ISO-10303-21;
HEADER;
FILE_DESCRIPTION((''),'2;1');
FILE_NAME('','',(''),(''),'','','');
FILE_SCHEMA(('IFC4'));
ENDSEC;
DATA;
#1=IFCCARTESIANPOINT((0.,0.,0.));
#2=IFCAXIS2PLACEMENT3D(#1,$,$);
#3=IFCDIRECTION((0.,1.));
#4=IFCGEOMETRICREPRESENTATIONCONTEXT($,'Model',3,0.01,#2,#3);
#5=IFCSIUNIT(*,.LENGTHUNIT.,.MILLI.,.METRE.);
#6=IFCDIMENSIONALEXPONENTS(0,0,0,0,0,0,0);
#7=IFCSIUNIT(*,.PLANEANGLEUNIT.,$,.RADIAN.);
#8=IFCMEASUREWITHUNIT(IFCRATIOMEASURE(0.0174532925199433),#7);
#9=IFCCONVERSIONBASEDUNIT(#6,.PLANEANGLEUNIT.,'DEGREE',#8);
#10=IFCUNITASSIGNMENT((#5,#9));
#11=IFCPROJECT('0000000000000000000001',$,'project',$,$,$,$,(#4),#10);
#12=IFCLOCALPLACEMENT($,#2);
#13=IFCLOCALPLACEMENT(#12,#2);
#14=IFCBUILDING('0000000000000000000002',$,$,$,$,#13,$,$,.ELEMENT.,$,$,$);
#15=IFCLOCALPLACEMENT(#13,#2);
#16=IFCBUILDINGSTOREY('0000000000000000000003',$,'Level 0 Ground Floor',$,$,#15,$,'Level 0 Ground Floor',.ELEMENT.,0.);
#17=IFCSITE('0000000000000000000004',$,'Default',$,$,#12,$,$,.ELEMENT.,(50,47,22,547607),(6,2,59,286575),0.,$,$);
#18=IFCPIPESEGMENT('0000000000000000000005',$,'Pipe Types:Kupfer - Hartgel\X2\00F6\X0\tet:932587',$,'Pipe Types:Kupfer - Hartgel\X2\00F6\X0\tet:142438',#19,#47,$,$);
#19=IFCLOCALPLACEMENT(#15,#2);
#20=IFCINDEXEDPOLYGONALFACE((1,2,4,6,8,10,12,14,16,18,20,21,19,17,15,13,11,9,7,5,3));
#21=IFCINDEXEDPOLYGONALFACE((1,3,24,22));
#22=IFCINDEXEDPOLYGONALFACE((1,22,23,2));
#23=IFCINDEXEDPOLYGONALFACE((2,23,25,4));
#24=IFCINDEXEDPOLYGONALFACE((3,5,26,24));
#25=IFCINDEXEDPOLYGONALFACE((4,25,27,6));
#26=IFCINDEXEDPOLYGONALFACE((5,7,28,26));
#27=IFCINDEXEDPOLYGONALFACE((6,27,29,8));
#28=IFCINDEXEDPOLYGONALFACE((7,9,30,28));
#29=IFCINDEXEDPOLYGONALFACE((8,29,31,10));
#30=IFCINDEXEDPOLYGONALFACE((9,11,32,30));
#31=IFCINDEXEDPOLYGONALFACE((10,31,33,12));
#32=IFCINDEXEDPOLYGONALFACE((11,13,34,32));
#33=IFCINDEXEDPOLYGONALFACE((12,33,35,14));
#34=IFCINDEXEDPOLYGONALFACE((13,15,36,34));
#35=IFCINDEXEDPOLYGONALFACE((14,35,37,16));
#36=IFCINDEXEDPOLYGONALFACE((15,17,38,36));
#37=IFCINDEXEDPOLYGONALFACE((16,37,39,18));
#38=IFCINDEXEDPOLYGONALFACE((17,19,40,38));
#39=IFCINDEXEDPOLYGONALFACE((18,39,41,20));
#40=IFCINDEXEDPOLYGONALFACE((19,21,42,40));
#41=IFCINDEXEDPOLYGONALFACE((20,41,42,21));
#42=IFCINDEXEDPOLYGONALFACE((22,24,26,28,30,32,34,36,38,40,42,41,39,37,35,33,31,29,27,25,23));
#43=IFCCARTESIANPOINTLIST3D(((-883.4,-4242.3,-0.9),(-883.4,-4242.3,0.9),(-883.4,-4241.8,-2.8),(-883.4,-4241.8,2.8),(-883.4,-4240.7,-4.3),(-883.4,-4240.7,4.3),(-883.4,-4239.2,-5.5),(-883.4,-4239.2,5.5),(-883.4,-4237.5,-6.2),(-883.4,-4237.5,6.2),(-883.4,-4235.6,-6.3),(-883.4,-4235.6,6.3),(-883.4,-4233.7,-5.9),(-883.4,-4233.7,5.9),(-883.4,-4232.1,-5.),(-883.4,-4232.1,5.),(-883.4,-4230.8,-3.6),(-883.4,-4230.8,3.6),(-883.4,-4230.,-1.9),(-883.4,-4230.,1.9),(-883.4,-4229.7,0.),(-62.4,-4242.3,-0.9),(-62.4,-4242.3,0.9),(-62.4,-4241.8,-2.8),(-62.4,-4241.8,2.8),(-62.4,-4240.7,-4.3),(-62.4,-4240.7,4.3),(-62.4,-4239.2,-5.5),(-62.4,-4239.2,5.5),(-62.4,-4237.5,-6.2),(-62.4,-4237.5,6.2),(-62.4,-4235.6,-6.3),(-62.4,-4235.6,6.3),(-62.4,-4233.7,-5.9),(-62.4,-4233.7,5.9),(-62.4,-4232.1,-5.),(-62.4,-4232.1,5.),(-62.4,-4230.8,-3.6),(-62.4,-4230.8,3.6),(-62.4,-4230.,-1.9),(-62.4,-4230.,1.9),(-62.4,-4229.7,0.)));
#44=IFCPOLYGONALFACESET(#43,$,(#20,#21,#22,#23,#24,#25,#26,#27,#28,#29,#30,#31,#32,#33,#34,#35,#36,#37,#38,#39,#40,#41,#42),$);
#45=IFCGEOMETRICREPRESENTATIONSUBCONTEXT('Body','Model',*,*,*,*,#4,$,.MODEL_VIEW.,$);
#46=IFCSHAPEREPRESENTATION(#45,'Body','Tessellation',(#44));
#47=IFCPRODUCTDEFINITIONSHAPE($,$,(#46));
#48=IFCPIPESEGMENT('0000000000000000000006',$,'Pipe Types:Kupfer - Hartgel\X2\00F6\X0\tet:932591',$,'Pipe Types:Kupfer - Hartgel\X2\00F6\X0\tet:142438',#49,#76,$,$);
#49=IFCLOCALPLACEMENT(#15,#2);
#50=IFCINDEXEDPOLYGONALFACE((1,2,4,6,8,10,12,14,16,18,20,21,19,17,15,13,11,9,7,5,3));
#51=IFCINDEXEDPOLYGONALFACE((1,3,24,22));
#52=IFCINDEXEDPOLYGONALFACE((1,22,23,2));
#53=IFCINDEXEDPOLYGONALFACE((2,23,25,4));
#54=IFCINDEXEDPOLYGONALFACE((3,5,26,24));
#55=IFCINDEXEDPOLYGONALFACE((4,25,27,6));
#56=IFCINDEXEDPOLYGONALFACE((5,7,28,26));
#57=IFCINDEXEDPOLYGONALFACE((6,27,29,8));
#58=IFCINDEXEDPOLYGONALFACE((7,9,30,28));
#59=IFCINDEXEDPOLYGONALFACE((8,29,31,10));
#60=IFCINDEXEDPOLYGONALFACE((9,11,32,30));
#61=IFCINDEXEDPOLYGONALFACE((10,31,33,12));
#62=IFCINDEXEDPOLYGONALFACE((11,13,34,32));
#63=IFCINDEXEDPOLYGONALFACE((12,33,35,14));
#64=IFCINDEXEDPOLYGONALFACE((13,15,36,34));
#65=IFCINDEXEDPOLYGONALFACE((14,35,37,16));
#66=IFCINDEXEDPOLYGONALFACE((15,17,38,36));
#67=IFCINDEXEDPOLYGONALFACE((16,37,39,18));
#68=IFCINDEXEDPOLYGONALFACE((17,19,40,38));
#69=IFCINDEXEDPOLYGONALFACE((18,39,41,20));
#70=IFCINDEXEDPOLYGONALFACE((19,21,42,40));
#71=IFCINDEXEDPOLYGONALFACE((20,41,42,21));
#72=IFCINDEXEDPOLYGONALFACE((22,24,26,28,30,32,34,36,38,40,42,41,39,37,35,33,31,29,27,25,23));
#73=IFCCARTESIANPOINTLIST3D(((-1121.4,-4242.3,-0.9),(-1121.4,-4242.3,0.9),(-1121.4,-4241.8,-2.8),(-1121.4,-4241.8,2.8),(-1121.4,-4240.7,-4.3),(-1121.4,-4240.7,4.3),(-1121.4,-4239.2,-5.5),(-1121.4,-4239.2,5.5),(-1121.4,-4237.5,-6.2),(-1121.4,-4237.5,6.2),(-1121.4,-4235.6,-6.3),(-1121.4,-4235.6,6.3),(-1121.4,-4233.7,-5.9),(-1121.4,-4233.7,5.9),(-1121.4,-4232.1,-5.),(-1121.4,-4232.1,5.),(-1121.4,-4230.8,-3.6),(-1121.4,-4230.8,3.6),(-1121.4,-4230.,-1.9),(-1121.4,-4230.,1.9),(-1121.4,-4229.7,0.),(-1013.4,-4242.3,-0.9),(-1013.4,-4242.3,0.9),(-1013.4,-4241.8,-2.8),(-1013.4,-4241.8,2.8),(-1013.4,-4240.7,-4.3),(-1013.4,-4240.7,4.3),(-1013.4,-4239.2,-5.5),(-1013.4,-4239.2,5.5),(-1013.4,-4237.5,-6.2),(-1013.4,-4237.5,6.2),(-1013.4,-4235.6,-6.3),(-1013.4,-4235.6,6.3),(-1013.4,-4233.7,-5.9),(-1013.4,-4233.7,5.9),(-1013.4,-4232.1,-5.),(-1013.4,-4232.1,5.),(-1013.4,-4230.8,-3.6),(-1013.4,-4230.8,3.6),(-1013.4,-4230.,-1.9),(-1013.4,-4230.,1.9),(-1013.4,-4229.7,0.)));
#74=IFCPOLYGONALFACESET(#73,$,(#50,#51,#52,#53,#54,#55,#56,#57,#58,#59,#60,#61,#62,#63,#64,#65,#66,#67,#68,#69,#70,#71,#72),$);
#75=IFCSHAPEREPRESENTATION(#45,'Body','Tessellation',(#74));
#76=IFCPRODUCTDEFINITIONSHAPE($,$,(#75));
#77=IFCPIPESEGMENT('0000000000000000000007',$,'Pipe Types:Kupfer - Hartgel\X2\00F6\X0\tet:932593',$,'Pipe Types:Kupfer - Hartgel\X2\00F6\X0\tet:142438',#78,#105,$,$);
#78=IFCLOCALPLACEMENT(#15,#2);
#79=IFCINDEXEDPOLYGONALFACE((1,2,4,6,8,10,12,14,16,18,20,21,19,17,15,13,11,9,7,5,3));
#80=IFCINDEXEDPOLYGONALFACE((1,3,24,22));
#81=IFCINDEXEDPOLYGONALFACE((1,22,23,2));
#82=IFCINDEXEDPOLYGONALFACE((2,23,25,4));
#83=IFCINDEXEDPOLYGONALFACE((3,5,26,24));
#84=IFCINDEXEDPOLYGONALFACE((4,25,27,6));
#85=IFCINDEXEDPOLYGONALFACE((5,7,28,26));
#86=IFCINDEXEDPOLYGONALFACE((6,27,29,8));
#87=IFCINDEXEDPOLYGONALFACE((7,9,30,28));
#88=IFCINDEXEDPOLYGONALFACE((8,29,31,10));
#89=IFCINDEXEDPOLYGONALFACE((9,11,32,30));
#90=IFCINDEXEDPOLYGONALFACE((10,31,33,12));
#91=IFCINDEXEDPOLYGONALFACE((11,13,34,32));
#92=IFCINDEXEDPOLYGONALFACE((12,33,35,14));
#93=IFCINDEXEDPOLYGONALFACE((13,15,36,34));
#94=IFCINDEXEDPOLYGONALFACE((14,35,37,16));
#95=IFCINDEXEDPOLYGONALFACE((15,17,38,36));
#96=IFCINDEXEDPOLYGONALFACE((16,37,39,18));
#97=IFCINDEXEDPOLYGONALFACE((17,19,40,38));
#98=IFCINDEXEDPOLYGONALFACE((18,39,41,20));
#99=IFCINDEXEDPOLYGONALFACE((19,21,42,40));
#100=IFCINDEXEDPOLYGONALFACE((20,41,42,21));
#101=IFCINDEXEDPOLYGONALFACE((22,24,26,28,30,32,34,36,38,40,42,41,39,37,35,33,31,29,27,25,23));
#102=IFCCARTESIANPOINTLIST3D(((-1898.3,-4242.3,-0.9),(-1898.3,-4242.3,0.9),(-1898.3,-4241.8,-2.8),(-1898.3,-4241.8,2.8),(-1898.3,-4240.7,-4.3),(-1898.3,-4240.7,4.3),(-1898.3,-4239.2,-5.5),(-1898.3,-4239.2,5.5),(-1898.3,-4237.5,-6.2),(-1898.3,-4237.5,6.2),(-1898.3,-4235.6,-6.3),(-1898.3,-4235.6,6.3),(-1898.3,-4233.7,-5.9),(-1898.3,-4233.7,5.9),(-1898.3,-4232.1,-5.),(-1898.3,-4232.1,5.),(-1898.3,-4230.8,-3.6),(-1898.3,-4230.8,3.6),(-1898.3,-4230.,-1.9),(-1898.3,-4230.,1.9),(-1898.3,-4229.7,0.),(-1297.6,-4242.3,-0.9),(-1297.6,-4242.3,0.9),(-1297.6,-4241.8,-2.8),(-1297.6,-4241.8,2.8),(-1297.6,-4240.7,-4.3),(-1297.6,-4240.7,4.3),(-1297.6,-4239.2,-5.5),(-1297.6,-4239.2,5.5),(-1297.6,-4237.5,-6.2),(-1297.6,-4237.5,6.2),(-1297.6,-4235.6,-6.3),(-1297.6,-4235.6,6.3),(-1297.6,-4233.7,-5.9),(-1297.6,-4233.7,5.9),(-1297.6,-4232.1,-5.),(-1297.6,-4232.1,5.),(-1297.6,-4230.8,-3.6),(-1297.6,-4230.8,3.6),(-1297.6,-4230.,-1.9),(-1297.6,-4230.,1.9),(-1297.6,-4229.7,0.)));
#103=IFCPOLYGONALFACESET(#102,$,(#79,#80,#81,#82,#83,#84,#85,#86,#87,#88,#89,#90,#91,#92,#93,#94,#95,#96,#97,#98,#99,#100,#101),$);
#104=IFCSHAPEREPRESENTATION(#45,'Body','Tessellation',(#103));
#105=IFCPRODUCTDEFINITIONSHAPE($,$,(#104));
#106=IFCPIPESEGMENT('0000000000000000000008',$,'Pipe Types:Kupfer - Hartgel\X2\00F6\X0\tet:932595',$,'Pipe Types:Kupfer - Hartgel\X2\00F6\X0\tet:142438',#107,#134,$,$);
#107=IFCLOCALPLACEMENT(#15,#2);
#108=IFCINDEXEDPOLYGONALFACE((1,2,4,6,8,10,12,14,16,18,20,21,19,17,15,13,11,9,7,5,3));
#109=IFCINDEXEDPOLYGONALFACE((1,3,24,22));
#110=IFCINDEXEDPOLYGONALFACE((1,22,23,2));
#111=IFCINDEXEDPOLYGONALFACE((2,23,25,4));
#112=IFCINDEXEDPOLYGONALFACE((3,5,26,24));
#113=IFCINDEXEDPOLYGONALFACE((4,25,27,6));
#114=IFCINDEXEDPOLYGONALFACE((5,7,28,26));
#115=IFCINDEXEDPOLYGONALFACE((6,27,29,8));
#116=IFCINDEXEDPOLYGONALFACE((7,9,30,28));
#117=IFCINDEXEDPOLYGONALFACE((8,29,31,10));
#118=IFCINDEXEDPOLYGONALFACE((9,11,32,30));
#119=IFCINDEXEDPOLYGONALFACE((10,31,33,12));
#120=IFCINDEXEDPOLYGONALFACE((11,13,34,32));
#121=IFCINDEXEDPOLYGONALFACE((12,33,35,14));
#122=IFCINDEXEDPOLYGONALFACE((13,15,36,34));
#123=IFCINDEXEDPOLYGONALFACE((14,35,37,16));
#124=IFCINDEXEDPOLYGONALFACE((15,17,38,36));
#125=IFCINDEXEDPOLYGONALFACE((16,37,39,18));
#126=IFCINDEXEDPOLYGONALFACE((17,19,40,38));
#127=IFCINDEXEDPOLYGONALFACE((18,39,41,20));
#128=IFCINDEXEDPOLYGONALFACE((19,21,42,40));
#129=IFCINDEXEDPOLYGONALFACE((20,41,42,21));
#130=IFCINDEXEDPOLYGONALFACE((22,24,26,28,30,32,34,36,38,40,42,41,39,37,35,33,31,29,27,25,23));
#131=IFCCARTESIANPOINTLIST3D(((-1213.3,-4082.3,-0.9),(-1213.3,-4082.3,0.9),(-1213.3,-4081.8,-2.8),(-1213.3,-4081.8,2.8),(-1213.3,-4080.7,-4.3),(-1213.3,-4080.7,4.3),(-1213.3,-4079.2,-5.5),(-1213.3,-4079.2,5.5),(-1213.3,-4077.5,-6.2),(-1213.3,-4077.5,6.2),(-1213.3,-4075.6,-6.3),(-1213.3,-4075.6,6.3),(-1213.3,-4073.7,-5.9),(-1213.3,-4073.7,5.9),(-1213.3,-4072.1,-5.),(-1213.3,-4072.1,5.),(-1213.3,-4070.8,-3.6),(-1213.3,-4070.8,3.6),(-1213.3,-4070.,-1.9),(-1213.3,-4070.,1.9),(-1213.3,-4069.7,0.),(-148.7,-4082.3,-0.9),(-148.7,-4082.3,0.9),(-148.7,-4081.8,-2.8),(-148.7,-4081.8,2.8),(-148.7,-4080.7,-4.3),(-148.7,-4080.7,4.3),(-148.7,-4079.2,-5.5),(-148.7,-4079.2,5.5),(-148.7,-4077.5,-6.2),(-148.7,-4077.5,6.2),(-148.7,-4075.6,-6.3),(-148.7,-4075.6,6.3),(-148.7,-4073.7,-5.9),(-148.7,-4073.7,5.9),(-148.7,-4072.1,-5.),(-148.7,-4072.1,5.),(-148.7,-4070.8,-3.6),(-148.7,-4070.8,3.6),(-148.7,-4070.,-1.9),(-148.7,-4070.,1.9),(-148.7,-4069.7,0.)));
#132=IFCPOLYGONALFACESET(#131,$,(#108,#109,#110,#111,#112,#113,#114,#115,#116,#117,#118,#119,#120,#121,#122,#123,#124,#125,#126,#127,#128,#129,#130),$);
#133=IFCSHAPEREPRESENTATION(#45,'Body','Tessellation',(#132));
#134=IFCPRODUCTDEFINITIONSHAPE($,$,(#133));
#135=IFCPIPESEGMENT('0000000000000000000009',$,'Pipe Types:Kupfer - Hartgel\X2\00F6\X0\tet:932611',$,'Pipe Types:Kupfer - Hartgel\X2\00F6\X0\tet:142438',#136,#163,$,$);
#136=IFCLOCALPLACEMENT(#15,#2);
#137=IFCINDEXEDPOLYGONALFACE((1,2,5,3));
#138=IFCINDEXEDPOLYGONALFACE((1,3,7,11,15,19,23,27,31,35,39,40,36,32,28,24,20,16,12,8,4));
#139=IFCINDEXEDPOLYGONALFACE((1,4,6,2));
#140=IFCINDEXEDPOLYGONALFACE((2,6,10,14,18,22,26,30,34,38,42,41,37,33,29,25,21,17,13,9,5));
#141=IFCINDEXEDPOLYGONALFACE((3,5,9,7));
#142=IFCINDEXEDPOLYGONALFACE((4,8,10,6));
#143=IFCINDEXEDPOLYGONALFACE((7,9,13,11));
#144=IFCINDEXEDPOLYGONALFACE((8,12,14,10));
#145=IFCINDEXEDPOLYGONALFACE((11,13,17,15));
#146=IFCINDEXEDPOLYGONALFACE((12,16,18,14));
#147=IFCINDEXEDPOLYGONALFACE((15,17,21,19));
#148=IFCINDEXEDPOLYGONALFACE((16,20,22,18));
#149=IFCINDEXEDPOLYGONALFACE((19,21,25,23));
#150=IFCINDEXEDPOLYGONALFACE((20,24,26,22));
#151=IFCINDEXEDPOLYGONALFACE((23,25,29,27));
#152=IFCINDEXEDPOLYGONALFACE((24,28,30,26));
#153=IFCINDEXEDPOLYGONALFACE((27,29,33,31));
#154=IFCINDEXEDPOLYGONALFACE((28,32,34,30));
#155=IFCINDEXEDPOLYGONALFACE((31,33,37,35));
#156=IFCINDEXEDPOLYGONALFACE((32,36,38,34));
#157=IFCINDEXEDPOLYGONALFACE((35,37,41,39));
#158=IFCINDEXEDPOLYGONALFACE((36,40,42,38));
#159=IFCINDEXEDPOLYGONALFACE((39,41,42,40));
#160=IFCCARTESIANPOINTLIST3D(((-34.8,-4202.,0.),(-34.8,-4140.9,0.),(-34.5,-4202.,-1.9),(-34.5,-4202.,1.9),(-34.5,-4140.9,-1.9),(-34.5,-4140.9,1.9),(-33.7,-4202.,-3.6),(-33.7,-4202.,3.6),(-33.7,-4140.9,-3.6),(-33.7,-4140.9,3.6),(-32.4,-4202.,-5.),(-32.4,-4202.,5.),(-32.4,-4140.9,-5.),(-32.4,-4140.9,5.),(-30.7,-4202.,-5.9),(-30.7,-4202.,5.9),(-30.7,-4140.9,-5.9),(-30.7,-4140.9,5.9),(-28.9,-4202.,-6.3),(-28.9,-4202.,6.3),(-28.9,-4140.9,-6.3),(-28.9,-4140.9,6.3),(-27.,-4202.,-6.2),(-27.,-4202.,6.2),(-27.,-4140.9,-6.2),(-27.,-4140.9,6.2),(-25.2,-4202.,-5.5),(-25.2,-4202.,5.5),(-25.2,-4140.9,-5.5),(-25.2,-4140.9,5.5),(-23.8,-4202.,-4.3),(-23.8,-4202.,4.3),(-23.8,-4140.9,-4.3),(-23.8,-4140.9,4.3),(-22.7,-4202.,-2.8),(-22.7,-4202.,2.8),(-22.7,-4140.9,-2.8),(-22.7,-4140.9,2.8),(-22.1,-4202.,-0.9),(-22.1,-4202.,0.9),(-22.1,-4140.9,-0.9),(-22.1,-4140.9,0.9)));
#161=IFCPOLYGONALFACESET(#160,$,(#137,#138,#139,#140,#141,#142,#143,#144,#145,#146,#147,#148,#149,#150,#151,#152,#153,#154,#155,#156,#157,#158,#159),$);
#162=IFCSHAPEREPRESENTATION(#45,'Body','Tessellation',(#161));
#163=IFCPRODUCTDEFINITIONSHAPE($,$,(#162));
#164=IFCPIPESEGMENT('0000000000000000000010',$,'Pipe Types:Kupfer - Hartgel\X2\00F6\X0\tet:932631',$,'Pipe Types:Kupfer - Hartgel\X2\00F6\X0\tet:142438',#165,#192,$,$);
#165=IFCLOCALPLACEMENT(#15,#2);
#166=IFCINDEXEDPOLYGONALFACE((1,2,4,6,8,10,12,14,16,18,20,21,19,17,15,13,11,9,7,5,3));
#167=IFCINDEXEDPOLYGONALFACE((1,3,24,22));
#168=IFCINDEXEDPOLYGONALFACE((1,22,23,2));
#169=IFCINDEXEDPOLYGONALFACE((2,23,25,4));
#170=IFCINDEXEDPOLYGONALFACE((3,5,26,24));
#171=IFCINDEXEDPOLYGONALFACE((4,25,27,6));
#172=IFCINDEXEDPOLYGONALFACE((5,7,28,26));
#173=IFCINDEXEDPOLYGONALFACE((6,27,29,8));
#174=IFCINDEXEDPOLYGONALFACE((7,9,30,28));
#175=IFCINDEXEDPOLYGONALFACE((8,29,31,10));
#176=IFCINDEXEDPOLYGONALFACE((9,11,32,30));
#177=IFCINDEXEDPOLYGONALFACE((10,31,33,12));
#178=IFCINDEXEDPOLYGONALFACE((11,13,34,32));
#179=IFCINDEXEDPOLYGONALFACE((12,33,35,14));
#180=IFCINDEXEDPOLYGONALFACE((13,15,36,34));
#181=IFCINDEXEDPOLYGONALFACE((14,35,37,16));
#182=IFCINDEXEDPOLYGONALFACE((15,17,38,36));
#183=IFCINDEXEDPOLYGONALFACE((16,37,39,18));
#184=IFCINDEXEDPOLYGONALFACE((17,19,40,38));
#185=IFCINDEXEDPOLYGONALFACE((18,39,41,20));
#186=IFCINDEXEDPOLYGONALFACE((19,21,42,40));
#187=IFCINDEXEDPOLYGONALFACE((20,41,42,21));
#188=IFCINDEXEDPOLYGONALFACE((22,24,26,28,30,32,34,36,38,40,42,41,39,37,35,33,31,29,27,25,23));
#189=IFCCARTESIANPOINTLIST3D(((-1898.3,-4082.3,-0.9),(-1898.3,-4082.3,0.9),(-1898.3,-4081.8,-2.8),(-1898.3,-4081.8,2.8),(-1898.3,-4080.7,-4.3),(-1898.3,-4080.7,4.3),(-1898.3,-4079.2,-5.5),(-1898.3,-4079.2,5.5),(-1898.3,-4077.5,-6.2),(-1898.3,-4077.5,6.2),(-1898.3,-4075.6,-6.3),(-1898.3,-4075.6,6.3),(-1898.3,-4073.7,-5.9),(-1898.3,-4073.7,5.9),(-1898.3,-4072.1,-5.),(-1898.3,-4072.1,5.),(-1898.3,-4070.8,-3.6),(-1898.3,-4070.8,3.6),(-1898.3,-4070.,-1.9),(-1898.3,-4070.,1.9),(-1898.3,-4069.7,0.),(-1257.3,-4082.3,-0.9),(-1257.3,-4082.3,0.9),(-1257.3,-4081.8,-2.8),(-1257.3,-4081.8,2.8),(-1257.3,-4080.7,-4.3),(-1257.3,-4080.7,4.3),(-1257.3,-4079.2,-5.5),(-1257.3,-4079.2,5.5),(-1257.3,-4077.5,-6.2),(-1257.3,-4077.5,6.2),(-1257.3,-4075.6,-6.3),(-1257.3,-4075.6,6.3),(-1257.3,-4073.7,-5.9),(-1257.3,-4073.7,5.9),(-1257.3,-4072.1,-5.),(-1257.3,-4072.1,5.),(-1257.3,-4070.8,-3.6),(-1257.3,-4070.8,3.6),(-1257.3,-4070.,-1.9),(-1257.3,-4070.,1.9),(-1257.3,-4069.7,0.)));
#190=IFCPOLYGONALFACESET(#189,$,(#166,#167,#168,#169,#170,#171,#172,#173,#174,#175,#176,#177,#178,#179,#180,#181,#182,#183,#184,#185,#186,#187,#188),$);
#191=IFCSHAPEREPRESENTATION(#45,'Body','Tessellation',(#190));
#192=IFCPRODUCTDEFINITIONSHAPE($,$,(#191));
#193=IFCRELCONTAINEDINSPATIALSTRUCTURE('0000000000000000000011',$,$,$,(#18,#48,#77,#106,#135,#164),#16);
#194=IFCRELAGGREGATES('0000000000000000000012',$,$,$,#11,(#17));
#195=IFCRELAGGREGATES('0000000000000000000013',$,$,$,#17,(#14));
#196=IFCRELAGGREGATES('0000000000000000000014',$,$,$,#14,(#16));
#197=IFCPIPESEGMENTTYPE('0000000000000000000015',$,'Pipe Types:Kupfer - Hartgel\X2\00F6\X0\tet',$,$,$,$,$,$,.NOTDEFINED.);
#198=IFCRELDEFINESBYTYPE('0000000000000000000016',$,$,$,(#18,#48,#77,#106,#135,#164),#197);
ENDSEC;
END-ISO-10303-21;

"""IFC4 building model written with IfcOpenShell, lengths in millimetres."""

from ifc_helpers import new_model, entity, si_unit, converted_unit, direction, frame, frame_2d, origin, place, context, subcontext, project, spatial, circle, extrude, type_object, element, save


model = new_model("IFC4")

# Units and contexts
model_context = context("Model", 3, precision=0.01, world=origin(), true_north=direction((0.0, 1.0)))
body_context = subcontext(model_context, "Body", "Model", "MODEL_VIEW")
ifc_project = project(units=[si_unit("LENGTHUNIT", "METRE", prefix="MILLI"), converted_unit("PLANEANGLEUNIT", "DEGREE", entity("IfcRatioMeasure", 0.0174532925199433), si_unit("PLANEANGLEUNIT", "RADIAN"), dimensions=[0, 0, 0, 0, 0, 0, 0])], contexts=[model_context])

# Site, building, storey
site_placement = place(None, origin())
site = spatial("IfcSite", under=ifc_project, at=site_placement, Name="Default", CompositionType="ELEMENT", RefLatitude=(50, 47, 22, 547607), RefLongitude=(6, 2, 59, 286575), RefElevation=0.0)
building_placement = place(site_placement, origin())
building = spatial("IfcBuilding", under=site, at=building_placement, CompositionType="ELEMENT")
storey_placement = place(building_placement, origin())
storey = spatial("IfcBuildingStorey", under=building, at=storey_placement, Name="Level 0 Ground Floor", LongName="Level 0 Ground Floor", CompositionType="ELEMENT", Elevation=0.0)

# Pipe segments
pipe_segment_type_1 = type_object("IfcPipeSegmentType", Name="Pipe Types:Kupfer - Hartgelötet", PredefinedType="NOTDEFINED")
pipe_segment_1_placement = place(storey_placement, frame((-883.4, -4244.0, -7.9)))
element("IfcPipeSegment", 1, at=pipe_segment_1_placement, inside=storey, type_object=pipe_segment_type_1, Name="Pipe Types:Kupfer - Hartgelötet:932587", ObjectType="Pipe Types:Kupfer - Hartgelötet:142438", context=body_context, shape_type="SweptSolid", body=[
    extrude(circle(Radius=6.3, at=frame_2d((0.0, 0.0), x_axis=(1.0, 0.0))), frame((0.0, 7.9, 7.9), z_axis=(1.0, 0.0, 0.0), x_axis=(0.0, 1.0, 0.0)), (0.0, 0.0, 1.0), 821.0),
])
pipe_segment_2_placement = place(storey_placement, frame((-1121.4, -4244.0, -7.9)))
element("IfcPipeSegment", 2, at=pipe_segment_2_placement, inside=storey, type_object=pipe_segment_type_1, Name="Pipe Types:Kupfer - Hartgelötet:932591", ObjectType="Pipe Types:Kupfer - Hartgelötet:142438", context=body_context, shape_type="SweptSolid", body=[
    extrude(circle(Radius=6.3, at=frame_2d((0.0, 0.0), x_axis=(1.0, 0.0))), frame((0.0, 7.9, 7.9), z_axis=(1.0, 0.0, 0.0), x_axis=(0.0, 1.0, 0.0)), (0.0, 0.0, 1.0), 108.0),
])
pipe_segment_3_placement = place(storey_placement, frame((-1898.3, -4244.0, -7.9)))
element("IfcPipeSegment", 3, at=pipe_segment_3_placement, inside=storey, type_object=pipe_segment_type_1, Name="Pipe Types:Kupfer - Hartgelötet:932593", ObjectType="Pipe Types:Kupfer - Hartgelötet:142438", context=body_context, shape_type="SweptSolid", body=[
    extrude(circle(Radius=6.3, at=frame_2d((0.0, 0.0), x_axis=(1.0, 0.0))), frame((0.0, 7.9, 7.9), z_axis=(1.0, 0.0, 0.0), x_axis=(0.0, 1.0, 0.0)), (0.0, 0.0, 1.0), 600.7),
])
pipe_segment_4_placement = place(storey_placement, frame((-1213.3, -4084.0, -7.9)))
element("IfcPipeSegment", 4, at=pipe_segment_4_placement, inside=storey, type_object=pipe_segment_type_1, Name="Pipe Types:Kupfer - Hartgelötet:932595", ObjectType="Pipe Types:Kupfer - Hartgelötet:142438", context=body_context, shape_type="SweptSolid", body=[
    extrude(circle(Radius=6.3, at=frame_2d((0.0, 0.0), x_axis=(1.0, 0.0))), frame((0.0, 7.9, 7.9), z_axis=(1.0, 0.0, 0.0), x_axis=(0.0, 1.0, 0.0)), (0.0, 0.0, 1.0), 1064.6),
])
pipe_segment_5_placement = place(storey_placement, frame((-36.4, -4202.0, -7.9)))
element("IfcPipeSegment", 5, at=pipe_segment_5_placement, inside=storey, type_object=pipe_segment_type_1, Name="Pipe Types:Kupfer - Hartgelötet:932611", ObjectType="Pipe Types:Kupfer - Hartgelötet:142438", context=body_context, shape_type="SweptSolid", body=[
    extrude(circle(Radius=6.3, at=frame_2d((0.0, 0.0), x_axis=(1.0, 0.0))), frame((7.9, 0.0, 7.9), z_axis=(0.0, 1.0, 0.0), x_axis=(-1.0, 0.0, 0.0)), (0.0, 0.0, 1.0), 61.1),
])
pipe_segment_6_placement = place(storey_placement, frame((-1898.3, -4084.0, -7.9)))
element("IfcPipeSegment", 6, at=pipe_segment_6_placement, inside=storey, type_object=pipe_segment_type_1, Name="Pipe Types:Kupfer - Hartgelötet:932631", ObjectType="Pipe Types:Kupfer - Hartgelötet:142438", context=body_context, shape_type="SweptSolid", body=[
    extrude(circle(Radius=6.3, at=frame_2d((0.0, 0.0), x_axis=(1.0, 0.0))), frame((0.0, 7.9, 7.9), z_axis=(1.0, 0.0, 0.0), x_axis=(0.0, 1.0, 0.0)), (0.0, 0.0, 1.0), 641.0),
])

save(model, "model.ifc")
